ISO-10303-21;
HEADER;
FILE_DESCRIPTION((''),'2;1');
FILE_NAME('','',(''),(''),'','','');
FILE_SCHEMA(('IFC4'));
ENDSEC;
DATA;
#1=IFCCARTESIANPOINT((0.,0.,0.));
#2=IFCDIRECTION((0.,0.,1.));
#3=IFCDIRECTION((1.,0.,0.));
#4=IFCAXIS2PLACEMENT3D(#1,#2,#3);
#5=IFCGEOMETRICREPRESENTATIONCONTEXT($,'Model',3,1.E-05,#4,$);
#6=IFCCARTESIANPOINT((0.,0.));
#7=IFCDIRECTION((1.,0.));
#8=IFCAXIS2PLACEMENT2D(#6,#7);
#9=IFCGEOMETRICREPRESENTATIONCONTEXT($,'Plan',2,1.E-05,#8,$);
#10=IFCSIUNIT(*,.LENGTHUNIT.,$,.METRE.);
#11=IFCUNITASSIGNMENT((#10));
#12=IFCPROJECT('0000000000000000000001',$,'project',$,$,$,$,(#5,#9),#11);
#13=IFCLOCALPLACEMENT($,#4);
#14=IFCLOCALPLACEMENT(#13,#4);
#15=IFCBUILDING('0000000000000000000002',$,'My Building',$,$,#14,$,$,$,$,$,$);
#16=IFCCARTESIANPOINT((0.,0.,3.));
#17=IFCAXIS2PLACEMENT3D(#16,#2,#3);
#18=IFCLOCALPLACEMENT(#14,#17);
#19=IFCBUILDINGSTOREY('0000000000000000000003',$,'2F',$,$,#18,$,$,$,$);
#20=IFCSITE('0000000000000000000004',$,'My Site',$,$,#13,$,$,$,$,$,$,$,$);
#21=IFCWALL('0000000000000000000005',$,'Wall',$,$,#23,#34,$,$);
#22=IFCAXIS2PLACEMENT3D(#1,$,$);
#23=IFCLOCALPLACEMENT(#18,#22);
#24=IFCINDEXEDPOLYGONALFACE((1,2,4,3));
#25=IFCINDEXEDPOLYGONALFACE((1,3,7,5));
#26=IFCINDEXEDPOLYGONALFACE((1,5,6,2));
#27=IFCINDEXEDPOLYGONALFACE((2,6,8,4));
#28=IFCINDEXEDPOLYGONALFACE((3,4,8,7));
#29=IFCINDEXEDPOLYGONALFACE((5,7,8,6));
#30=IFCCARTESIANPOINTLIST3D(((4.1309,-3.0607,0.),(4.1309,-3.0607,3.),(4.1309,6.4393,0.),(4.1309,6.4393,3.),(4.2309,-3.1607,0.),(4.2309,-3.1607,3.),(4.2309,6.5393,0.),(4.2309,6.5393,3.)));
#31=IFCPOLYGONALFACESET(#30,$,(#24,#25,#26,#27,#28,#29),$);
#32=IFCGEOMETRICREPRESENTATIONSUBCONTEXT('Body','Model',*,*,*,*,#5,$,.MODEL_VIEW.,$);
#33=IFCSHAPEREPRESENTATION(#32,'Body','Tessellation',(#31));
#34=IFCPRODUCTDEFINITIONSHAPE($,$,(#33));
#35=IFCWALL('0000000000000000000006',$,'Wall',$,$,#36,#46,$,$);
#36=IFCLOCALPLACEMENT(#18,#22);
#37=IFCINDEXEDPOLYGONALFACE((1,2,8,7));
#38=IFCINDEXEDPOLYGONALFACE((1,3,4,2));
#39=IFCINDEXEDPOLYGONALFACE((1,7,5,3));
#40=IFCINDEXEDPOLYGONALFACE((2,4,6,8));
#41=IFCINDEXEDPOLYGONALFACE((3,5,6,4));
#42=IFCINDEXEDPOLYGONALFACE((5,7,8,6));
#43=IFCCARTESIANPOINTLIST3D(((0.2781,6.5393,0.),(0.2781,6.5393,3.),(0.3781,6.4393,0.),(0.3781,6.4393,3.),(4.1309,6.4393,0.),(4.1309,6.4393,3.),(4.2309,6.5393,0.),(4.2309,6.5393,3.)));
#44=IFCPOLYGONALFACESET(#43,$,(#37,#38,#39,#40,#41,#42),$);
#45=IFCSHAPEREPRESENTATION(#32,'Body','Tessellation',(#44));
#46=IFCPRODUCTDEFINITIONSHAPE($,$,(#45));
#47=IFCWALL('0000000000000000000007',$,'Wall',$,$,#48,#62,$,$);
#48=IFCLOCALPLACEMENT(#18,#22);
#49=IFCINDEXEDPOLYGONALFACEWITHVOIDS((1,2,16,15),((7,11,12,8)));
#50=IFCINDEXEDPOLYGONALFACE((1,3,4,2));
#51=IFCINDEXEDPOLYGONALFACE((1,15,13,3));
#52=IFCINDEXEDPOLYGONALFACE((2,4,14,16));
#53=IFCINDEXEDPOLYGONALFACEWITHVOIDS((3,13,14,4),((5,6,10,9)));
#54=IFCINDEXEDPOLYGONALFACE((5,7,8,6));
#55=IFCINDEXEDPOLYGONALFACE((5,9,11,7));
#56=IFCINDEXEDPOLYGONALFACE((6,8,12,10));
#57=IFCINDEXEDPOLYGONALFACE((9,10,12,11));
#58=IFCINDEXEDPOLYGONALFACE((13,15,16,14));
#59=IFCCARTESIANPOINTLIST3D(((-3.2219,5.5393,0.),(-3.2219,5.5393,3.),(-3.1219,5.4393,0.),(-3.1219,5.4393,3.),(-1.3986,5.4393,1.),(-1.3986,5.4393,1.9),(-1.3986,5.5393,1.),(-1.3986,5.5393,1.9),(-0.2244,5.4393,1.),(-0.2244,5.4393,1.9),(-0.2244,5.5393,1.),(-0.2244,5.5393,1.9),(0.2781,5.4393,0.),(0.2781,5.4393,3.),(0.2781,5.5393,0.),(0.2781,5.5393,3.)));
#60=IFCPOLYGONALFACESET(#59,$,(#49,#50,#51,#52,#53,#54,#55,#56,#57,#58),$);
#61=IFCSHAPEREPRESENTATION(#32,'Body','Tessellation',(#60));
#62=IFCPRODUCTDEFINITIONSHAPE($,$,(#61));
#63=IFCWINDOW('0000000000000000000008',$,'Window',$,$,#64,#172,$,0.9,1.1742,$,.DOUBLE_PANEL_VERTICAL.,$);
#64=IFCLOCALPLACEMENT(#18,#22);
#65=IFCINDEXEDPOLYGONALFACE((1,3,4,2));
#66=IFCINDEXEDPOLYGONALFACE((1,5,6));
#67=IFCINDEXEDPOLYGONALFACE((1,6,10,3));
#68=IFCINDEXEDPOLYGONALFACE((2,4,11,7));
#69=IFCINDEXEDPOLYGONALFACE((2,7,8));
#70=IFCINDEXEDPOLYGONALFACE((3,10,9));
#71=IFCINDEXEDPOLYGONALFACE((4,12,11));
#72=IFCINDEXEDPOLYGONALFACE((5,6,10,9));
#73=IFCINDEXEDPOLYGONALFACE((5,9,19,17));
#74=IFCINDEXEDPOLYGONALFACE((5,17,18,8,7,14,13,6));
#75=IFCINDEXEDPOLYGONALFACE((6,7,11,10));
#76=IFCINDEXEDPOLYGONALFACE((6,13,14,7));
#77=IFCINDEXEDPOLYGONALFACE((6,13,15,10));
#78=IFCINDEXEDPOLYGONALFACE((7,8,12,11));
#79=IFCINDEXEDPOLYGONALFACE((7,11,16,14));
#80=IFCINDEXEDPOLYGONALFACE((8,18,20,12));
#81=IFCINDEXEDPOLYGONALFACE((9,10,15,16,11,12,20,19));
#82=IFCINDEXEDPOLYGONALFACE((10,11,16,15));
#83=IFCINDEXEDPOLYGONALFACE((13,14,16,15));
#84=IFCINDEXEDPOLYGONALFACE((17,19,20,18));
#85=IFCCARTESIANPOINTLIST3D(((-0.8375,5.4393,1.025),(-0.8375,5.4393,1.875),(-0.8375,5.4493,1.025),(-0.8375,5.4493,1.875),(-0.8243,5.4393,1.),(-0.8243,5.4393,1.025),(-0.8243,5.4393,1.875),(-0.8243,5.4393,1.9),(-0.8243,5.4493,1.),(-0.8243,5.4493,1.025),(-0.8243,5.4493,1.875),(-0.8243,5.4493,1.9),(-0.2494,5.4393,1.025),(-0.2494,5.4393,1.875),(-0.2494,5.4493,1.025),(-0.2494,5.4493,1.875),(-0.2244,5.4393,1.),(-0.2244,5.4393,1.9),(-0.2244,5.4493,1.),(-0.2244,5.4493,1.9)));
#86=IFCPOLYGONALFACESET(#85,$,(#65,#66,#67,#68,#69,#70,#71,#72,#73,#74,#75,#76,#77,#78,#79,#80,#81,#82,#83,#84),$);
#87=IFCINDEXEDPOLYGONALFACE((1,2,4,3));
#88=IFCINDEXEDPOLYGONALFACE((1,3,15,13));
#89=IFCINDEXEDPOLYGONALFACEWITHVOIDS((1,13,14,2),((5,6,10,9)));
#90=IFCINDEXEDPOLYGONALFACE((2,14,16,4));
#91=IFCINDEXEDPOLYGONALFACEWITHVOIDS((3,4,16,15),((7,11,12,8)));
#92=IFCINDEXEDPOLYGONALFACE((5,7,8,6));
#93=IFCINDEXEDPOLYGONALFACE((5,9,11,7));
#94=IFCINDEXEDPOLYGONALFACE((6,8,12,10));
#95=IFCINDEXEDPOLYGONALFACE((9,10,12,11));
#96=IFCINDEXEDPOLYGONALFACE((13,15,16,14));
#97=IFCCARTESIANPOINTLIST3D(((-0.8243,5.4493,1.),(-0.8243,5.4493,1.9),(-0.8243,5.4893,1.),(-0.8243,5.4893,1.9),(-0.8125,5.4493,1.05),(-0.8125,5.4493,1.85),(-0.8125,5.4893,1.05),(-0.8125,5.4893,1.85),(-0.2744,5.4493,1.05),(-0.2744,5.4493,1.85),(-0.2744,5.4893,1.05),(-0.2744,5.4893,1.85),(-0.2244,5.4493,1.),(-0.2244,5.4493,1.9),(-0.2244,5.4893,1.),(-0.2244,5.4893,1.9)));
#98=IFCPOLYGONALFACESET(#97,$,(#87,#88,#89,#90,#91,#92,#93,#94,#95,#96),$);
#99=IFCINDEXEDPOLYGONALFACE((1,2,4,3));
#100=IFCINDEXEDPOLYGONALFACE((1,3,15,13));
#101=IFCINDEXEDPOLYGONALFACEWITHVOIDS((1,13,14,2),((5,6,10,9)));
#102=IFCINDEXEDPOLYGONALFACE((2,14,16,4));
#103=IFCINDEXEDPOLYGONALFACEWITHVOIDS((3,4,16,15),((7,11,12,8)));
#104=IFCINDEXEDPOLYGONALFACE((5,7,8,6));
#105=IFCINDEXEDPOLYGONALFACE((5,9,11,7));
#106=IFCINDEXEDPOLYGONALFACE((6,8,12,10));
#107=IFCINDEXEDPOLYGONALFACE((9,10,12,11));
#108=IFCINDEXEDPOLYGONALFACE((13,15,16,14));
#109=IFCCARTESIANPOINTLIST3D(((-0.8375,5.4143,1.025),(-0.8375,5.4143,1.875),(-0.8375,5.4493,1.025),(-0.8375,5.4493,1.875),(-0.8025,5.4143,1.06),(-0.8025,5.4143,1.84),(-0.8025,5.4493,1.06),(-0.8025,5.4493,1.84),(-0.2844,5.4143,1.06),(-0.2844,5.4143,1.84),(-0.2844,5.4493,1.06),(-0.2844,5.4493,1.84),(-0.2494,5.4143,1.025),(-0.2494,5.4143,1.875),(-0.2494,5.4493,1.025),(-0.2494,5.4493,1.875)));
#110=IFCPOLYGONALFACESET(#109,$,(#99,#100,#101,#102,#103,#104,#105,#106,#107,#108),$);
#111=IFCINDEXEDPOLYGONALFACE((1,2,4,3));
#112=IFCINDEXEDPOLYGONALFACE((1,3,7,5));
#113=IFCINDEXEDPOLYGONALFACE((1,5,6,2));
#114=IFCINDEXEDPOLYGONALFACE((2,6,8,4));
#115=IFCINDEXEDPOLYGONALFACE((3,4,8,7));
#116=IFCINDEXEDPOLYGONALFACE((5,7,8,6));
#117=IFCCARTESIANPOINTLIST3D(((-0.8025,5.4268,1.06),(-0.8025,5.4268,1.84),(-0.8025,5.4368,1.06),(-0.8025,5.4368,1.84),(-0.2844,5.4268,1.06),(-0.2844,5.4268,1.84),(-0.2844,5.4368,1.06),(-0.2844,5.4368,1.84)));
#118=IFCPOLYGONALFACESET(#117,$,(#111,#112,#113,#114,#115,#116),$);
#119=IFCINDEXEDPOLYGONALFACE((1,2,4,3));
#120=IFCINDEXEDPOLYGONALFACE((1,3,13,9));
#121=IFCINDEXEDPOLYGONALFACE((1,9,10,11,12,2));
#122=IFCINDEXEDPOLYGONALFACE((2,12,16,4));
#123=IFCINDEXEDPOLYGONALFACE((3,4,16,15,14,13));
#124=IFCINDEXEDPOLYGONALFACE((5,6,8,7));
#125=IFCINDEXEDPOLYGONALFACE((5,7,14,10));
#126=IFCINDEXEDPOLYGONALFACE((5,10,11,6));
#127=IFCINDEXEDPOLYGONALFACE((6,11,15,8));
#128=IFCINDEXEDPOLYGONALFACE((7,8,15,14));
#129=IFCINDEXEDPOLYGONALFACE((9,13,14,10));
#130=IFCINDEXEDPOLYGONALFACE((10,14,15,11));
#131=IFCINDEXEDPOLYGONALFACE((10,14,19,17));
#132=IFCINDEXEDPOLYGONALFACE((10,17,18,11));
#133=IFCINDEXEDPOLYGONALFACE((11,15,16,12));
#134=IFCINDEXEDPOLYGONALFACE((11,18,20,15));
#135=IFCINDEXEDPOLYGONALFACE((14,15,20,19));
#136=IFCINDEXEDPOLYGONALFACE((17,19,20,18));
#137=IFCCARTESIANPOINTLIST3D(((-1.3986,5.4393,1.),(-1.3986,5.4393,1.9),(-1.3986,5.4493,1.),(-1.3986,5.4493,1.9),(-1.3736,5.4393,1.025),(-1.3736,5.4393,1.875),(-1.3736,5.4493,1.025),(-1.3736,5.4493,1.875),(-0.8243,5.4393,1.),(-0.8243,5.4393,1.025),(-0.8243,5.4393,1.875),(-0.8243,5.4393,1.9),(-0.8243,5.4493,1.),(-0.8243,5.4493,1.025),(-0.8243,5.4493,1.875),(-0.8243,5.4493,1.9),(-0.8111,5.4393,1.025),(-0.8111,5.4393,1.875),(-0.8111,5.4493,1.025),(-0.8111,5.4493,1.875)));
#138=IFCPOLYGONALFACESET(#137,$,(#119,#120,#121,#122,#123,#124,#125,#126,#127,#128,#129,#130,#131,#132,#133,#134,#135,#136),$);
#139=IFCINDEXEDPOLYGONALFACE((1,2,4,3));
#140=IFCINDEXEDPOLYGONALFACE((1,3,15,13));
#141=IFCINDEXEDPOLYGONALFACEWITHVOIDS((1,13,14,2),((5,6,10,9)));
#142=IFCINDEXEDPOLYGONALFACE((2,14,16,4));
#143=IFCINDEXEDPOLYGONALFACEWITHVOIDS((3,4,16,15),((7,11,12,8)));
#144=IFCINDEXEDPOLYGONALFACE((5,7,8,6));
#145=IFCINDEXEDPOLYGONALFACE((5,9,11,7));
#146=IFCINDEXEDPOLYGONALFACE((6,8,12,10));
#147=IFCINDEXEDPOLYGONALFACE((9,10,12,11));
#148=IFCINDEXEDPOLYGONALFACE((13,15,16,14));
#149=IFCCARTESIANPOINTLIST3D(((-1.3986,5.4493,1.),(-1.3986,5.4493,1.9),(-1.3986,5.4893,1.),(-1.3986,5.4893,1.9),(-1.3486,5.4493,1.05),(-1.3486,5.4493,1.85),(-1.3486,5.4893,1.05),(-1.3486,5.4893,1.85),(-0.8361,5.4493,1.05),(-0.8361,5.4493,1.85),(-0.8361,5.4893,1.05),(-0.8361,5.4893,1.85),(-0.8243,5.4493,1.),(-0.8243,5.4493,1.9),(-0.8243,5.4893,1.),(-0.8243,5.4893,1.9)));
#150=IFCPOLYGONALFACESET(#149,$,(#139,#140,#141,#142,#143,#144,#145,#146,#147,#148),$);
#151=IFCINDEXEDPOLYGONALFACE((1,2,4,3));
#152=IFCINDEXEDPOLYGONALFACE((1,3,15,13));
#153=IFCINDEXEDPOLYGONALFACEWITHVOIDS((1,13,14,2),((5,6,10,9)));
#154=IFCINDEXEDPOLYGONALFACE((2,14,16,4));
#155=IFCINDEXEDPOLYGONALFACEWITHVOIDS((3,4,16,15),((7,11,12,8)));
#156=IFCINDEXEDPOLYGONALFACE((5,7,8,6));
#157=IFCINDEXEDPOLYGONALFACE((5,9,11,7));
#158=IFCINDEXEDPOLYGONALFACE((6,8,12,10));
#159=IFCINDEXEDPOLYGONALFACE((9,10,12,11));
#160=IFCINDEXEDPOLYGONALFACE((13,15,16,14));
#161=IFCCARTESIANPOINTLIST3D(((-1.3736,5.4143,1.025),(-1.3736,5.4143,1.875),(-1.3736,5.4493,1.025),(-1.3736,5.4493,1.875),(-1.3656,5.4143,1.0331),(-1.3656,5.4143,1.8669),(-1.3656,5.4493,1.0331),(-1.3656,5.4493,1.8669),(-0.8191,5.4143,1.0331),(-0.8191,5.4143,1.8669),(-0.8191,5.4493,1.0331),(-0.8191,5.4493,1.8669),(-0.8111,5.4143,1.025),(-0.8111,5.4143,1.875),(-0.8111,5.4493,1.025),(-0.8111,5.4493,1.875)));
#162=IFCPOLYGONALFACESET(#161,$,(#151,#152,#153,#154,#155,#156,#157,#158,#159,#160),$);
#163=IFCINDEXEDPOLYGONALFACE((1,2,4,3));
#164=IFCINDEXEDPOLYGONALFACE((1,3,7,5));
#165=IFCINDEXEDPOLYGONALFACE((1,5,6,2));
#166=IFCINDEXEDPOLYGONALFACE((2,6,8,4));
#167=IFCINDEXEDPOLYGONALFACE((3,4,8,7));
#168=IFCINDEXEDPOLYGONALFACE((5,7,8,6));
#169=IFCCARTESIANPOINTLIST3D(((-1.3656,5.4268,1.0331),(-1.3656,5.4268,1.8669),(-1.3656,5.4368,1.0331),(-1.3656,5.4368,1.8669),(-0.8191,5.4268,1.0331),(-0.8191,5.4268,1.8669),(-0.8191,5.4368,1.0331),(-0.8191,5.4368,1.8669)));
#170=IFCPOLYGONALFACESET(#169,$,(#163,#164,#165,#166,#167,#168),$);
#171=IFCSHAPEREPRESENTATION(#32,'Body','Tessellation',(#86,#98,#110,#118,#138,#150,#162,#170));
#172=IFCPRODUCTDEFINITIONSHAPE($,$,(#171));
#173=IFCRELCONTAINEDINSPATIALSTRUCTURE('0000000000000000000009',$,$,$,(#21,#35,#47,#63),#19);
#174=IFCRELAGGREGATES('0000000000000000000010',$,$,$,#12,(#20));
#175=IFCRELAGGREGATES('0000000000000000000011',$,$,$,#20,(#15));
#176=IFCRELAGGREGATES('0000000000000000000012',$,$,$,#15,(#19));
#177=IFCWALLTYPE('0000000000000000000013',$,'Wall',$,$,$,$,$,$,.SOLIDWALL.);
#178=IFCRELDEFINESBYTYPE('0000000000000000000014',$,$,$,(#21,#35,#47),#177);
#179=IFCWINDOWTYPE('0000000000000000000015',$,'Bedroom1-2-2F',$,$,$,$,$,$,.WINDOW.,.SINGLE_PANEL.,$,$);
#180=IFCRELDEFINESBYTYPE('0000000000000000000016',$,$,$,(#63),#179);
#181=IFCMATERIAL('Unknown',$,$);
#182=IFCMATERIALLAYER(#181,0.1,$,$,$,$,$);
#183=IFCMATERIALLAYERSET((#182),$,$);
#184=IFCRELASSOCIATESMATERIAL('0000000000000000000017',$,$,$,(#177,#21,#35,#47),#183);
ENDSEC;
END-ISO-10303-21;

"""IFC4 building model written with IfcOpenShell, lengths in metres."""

from ifc_helpers import new_model, entity, si_unit, frame, origin_with_axes, origin_2d_with_axis, place, context, subcontext, project, spatial, line, indexed_curve, outline, extrude, shape, source, transform, mapped, material, layer, layer_set, layer_usage, type_object, type_shapes, element, fill, save


model = new_model("IFC4")

# Units and contexts
model_context = context("Model", 3, precision=1e-05, world=origin_with_axes())
plan_context = context("Plan", 2, precision=1e-05, world=origin_2d_with_axis())
body_context_1 = subcontext(model_context, "Body", "Model", "MODEL_VIEW")
body_context_2 = subcontext(plan_context, "Body", "Plan", "PLAN_VIEW")
ifc_project = project(units=[si_unit("LENGTHUNIT", "METRE")], contexts=[model_context, plan_context])

# Site, building, storey
site_placement = place(None, origin_with_axes())
site = spatial("IfcSite", under=ifc_project, at=site_placement, Name="My Site")
building_placement = place(site_placement, origin_with_axes())
building = spatial("IfcBuilding", under=site, at=building_placement, Name="My Building")
storey_placement = place(building_placement, frame((0.0, 0.0, 3.0), z_axis=(0.0, 0.0, 1.0), x_axis=(1.0, 0.0, 0.0)))
storey = spatial("IfcBuildingStorey", under=building, at=storey_placement, Name="2F")

# Walls
ifc_material = material(Name="Unknown")
ifc_layer = layer(ifc_material, 0.1)
ifc_layer_set = layer_set([ifc_layer])
ifc_layer_usage_1 = layer_usage(ifc_layer_set, "AXIS2", "POSITIVE", 0.0)
wall_type = type_object("IfcWallType", Name="Wall", PredefinedType="SOLIDWALL", material=ifc_layer_set)
wall_1_placement = place(storey_placement, frame((4.2309, -3.1607, 0.0), z_axis=(0.0, 0.0, 1.0), x_axis=(0.0, 1.0, 0.0)))
element("IfcWall", 1, at=wall_1_placement, inside=storey, type_object=wall_type, material=ifc_layer_usage_1, Name="Wall", context=body_context_1, shape_type="SweptSolid", body=[
    extrude(outline(indexed_curve([(0.0, 0.0), (0.1, 0.1), (9.6, 0.1), (9.7, 0.0)], segments=[line(1, 2, 3, 4, 1)])), origin_with_axes(), (0.0, 0.0, 1.0), 3.0),
])
ifc_layer_usage_2 = layer_usage(ifc_layer_set, "AXIS2", "POSITIVE", 0.0)
wall_2_placement = place(storey_placement, frame((4.2309, 6.5393, 0.0), z_axis=(0.0, 0.0, 1.0), x_axis=(-1.0, 0.0, 0.0)))
element("IfcWall", 2, at=wall_2_placement, inside=storey, type_object=wall_type, material=ifc_layer_usage_2, Name="Wall", context=body_context_1, shape_type="SweptSolid", body=[
    extrude(outline(indexed_curve([(0.0, 0.0), (0.1, 0.1), (3.8528, 0.1), (3.9528, 0.0)], segments=[line(1, 2, 3, 4, 1)])), origin_with_axes(), (0.0, 0.0, 1.0), 3.0),
])

# Wall, opening, window
ifc_layer_usage_3 = layer_usage(ifc_layer_set, "AXIS2", "POSITIVE", 0.0)
wall_3_placement = place(storey_placement, frame((0.2781, 5.5393, 0.0), z_axis=(0.0, 0.0, 1.0), x_axis=(-1.0, 0.0, 0.0)))
wall_3 = element("IfcWall", 3, at=wall_3_placement, inside=storey, type_object=wall_type, material=ifc_layer_usage_3, Name="Wall", context=body_context_1, shape_type="SweptSolid", body=[
    extrude(outline(indexed_curve([(0.0, 0.0), (0.0, 0.1), (3.4, 0.1), (3.5, 0.0)], segments=[line(1, 2, 3, 4, 1)])), origin_with_axes(), (0.0, 0.0, 1.0), 3.0),
])
shared_shape_1 = source(origin_with_axes(), body_context_1, "Body", "SweptSolid", [
    extrude(outline(indexed_curve([(0.0, 0.0), (1.1742, 0.0), (1.1742, 0.9), (0.0, 0.9)], segments=[line(1, 2, 3, 4, 1)])), frame((0.0, -0.6, 0.0), z_axis=(0.0, -1.0, 0.0), x_axis=(1.0, 0.0, 0.0)), (0.0, 0.0, -1.0), 1.2),
])
opening_1_placement = place(wall_3_placement, frame((0.5025, 0.0, 1.0), z_axis=(0.0, 0.0, 1.0), x_axis=(1.0, 0.0, 0.0)))
opening_1 = element("IfcOpeningElement", 4, at=opening_1_placement, cuts=wall_3, PredefinedType="OPENING", context=body_context_1, shape_type="MappedRepresentation", body=[
    mapped(shared_shape_1, transform((0.0, 0.0, 0.0), x_axis=(1.0, 0.0, 0.0), y_axis=(0.0, 1.0, 0.0), z_axis=(0.0, 0.0, 1.0), scale=1.0)),
])
window_type_1 = type_object("IfcWindowType", Name="Bedroom1-2-2F", PartitioningType="SINGLE_PANEL", PredefinedType="WINDOW")
shared_shape_2 = source(origin_with_axes(), body_context_1, "Body", "SweptSolid", [
    extrude(outline(indexed_curve([(0.0, 0.0), (0.5999, 0.0), (0.5999, 0.9), (0.0, 0.9)], segments=[line(1, 2, 3, 4, 1)]), holes=[indexed_curve([(0.025, 0.025), (0.6131, 0.025), (0.6131, 0.875), (0.025, 0.875)], segments=[line(1, 2, 3, 4, 1)])]), frame((0.0, 0.09, 0.0), z_axis=(0.0, -1.0, 0.0), x_axis=(1.0, 0.0, 0.0)), (0.0, 0.0, -1.0), 0.01),
    extrude(outline(indexed_curve([(0.0, 0.0), (0.5999, 0.0), (0.5999, 0.9), (0.0, 0.9)], segments=[line(1, 2, 3, 4, 1)]), holes=[indexed_curve([(0.05, 0.05), (0.5881, 0.05), (0.5881, 0.85), (0.05, 0.85)], segments=[line(1, 2, 3, 4, 1)])]), frame((0.0, 0.05, 0.0), z_axis=(0.0, -1.0, 0.0), x_axis=(1.0, 0.0, 0.0)), (0.0, 0.0, -1.0), 0.04),
    extrude(outline(indexed_curve([(0.0, 0.0), (0.5881, 0.0), (0.5881, 0.85), (0.0, 0.85)], segments=[line(1, 2, 3, 4, 1)]), holes=[indexed_curve([(0.035, 0.035), (0.5531, 0.035), (0.5531, 0.815), (0.035, 0.815)], segments=[line(1, 2, 3, 4, 1)])]), frame((0.025, 0.09, 0.025), z_axis=(0.0, -1.0, 0.0), x_axis=(1.0, 0.0, 0.0)), (0.0, 0.0, -1.0), 0.035),
    extrude(outline(indexed_curve([(0.035, 0.035), (0.5531, 0.035), (0.5531, 0.815), (0.035, 0.815)], segments=[line(1, 2, 3, 4, 1)])), frame((0.025, 0.1025, 0.025), z_axis=(0.0, -1.0, 0.0), x_axis=(1.0, 0.0, 0.0)), (0.0, 0.0, -1.0), 0.01),
    extrude(outline(indexed_curve([(0.0, 0.0), (0.5744, 0.0), (0.5744, 0.9), (0.0, 0.9)], segments=[line(1, 2, 3, 4, 1)]), holes=[indexed_curve([(-0.0132, 0.025), (0.5494, 0.025), (0.5494, 0.875), (-0.0132, 0.875)], segments=[line(1, 2, 3, 4, 1)])]), frame((0.5999, 0.09, 0.0), z_axis=(0.0, -1.0, 0.0), x_axis=(1.0, 0.0, 0.0)), (0.0, 0.0, -1.0), 0.01),
    extrude(outline(indexed_curve([(0.0, 0.0), (0.5744, 0.0), (0.5744, 0.9), (0.0, 0.9)], segments=[line(1, 2, 3, 4, 1)]), holes=[indexed_curve([(0.0118, 0.05), (0.5244, 0.05), (0.5244, 0.85), (0.0118, 0.85)], segments=[line(1, 2, 3, 4, 1)])]), frame((0.5999, 0.05, 0.0), z_axis=(0.0, -1.0, 0.0), x_axis=(1.0, 0.0, 0.0)), (0.0, 0.0, -1.0), 0.04),
    extrude(outline(indexed_curve([(0.0, 0.0), (0.5626, 0.0), (0.5626, 0.85), (0.0, 0.85)], segments=[line(1, 2, 3, 4, 1)]), holes=[indexed_curve([(0.0081, 0.0081), (0.5545, 0.0081), (0.5545, 0.8419), (0.0081, 0.8419)], segments=[line(1, 2, 3, 4, 1)])]), frame((0.5866, 0.09, 0.025), z_axis=(0.0, -1.0, 0.0), x_axis=(1.0, 0.0, 0.0)), (0.0, 0.0, -1.0), 0.035),
    extrude(outline(indexed_curve([(0.0081, 0.0081), (0.5545, 0.0081), (0.5545, 0.8419), (0.0081, 0.8419)], segments=[line(1, 2, 3, 4, 1)])), frame((0.5866, 0.1025, 0.025), z_axis=(0.0, -1.0, 0.0), x_axis=(1.0, 0.0, 0.0)), (0.0, 0.0, -1.0), 0.01),
])
shared_shape_3 = source(origin_with_axes(), body_context_2, "Body", "Curve2D", [
    entity("IfcIndexedPolyCurve", entity("IfcCartesianPointList2D", [[0.05, 0.05], [0.5881, 0.05]])),
    entity("IfcIndexedPolyCurve", entity("IfcCartesianPointList2D", [[0.0, 0.1], [0.025, 0.1], [0.025, 0.09], [0.05, 0.09], [0.05, 0.05], [0.0, 0.05]]), [entity("IfcLineIndex", [1, 2, 3, 4, 5, 6, 1])]),
    entity("IfcIndexedPolyCurve", entity("IfcCartesianPointList2D", [[0.5999, 0.1], [0.6131, 0.1], [0.6131, 0.09], [0.5881, 0.09], [0.5881, 0.05], [0.5999, 0.05]])),
    entity("IfcIndexedPolyCurve", entity("IfcCartesianPointList2D", [[0.025, 0.09], [0.06, 0.09], [0.06, 0.125], [0.025, 0.125]]), [entity("IfcLineIndex", [1, 2, 3, 4, 1])]),
    entity("IfcIndexedPolyCurve", entity("IfcCartesianPointList2D", [[0.6131, 0.09], [0.5781, 0.09], [0.5781, 0.125], [0.6131, 0.125]]), [entity("IfcLineIndex", [1, 2, 3, 4, 1])]),
    entity("IfcIndexedPolyCurve", entity("IfcCartesianPointList2D", [[0.06, 0.09], [0.5781, 0.09]])),
    entity("IfcIndexedPolyCurve", entity("IfcCartesianPointList2D", [[0.06, 0.125], [0.5781, 0.125]])),
    entity("IfcIndexedPolyCurve", entity("IfcCartesianPointList2D", [[0.06, 0.1075], [0.5781, 0.1075]])),
    entity("IfcIndexedPolyCurve", entity("IfcCartesianPointList2D", [[0.6116, 0.05], [1.1242, 0.05]])),
    entity("IfcIndexedPolyCurve", entity("IfcCartesianPointList2D", [[0.5999, 0.1], [0.5866, 0.1], [0.5866, 0.09], [0.6116, 0.09], [0.6116, 0.05], [0.5999, 0.05]])),
    entity("IfcIndexedPolyCurve", entity("IfcCartesianPointList2D", [[1.1742, 0.1], [1.1492, 0.1], [1.1492, 0.09], [1.1242, 0.09], [1.1242, 0.05], [1.1742, 0.05]]), [entity("IfcLineIndex", [1, 2, 3, 4, 5, 6, 1])]),
    entity("IfcIndexedPolyCurve", entity("IfcCartesianPointList2D", [[0.5866, 0.09], [0.5947, 0.09], [0.5947, 0.125], [0.5866, 0.125]]), [entity("IfcLineIndex", [1, 2, 3, 4, 1])]),
    entity("IfcIndexedPolyCurve", entity("IfcCartesianPointList2D", [[1.1492, 0.09], [1.1412, 0.09], [1.1412, 0.125], [1.1492, 0.125]]), [entity("IfcLineIndex", [1, 2, 3, 4, 1])]),
    entity("IfcIndexedPolyCurve", entity("IfcCartesianPointList2D", [[0.5947, 0.09], [1.1412, 0.09]])),
    entity("IfcIndexedPolyCurve", entity("IfcCartesianPointList2D", [[0.5947, 0.125], [1.1412, 0.125]])),
    entity("IfcIndexedPolyCurve", entity("IfcCartesianPointList2D", [[0.5947, 0.1075], [1.1412, 0.1075]])),
])
type_shapes(window_type_1, [shared_shape_2, shared_shape_3])
window_1_placement = place(opening_1_placement, frame((0.0, 0.0, 0.0), z_axis=(0.0, 0.0, 1.0), x_axis=(1.0, 0.0, 0.0)))
window_1 = element("IfcWindow", 5, at=window_1_placement, inside=storey, type_object=window_type_1, Name="Window", OverallHeight=0.9, OverallWidth=1.1742, PartitioningType="DOUBLE_PANEL_VERTICAL", shapes=[
    shape(body_context_1, "Body", "MappedRepresentation", [mapped(shared_shape_2, transform((0.0, 0.0, 0.0), x_axis=(1.0, 0.0, 0.0), y_axis=(0.0, 1.0, 0.0), z_axis=(0.0, 0.0, 1.0), scale=1.0))]),
    shape(body_context_2, "Body", "MappedRepresentation", [mapped(shared_shape_3, transform((0.0, 0.0, 0.0), x_axis=(1.0, 0.0, 0.0), y_axis=(0.0, 1.0, 0.0), z_axis=(0.0, 0.0, 1.0), scale=1.0))]),
])
fill(opening_1, window_1)

save(model, "model.ifc")
